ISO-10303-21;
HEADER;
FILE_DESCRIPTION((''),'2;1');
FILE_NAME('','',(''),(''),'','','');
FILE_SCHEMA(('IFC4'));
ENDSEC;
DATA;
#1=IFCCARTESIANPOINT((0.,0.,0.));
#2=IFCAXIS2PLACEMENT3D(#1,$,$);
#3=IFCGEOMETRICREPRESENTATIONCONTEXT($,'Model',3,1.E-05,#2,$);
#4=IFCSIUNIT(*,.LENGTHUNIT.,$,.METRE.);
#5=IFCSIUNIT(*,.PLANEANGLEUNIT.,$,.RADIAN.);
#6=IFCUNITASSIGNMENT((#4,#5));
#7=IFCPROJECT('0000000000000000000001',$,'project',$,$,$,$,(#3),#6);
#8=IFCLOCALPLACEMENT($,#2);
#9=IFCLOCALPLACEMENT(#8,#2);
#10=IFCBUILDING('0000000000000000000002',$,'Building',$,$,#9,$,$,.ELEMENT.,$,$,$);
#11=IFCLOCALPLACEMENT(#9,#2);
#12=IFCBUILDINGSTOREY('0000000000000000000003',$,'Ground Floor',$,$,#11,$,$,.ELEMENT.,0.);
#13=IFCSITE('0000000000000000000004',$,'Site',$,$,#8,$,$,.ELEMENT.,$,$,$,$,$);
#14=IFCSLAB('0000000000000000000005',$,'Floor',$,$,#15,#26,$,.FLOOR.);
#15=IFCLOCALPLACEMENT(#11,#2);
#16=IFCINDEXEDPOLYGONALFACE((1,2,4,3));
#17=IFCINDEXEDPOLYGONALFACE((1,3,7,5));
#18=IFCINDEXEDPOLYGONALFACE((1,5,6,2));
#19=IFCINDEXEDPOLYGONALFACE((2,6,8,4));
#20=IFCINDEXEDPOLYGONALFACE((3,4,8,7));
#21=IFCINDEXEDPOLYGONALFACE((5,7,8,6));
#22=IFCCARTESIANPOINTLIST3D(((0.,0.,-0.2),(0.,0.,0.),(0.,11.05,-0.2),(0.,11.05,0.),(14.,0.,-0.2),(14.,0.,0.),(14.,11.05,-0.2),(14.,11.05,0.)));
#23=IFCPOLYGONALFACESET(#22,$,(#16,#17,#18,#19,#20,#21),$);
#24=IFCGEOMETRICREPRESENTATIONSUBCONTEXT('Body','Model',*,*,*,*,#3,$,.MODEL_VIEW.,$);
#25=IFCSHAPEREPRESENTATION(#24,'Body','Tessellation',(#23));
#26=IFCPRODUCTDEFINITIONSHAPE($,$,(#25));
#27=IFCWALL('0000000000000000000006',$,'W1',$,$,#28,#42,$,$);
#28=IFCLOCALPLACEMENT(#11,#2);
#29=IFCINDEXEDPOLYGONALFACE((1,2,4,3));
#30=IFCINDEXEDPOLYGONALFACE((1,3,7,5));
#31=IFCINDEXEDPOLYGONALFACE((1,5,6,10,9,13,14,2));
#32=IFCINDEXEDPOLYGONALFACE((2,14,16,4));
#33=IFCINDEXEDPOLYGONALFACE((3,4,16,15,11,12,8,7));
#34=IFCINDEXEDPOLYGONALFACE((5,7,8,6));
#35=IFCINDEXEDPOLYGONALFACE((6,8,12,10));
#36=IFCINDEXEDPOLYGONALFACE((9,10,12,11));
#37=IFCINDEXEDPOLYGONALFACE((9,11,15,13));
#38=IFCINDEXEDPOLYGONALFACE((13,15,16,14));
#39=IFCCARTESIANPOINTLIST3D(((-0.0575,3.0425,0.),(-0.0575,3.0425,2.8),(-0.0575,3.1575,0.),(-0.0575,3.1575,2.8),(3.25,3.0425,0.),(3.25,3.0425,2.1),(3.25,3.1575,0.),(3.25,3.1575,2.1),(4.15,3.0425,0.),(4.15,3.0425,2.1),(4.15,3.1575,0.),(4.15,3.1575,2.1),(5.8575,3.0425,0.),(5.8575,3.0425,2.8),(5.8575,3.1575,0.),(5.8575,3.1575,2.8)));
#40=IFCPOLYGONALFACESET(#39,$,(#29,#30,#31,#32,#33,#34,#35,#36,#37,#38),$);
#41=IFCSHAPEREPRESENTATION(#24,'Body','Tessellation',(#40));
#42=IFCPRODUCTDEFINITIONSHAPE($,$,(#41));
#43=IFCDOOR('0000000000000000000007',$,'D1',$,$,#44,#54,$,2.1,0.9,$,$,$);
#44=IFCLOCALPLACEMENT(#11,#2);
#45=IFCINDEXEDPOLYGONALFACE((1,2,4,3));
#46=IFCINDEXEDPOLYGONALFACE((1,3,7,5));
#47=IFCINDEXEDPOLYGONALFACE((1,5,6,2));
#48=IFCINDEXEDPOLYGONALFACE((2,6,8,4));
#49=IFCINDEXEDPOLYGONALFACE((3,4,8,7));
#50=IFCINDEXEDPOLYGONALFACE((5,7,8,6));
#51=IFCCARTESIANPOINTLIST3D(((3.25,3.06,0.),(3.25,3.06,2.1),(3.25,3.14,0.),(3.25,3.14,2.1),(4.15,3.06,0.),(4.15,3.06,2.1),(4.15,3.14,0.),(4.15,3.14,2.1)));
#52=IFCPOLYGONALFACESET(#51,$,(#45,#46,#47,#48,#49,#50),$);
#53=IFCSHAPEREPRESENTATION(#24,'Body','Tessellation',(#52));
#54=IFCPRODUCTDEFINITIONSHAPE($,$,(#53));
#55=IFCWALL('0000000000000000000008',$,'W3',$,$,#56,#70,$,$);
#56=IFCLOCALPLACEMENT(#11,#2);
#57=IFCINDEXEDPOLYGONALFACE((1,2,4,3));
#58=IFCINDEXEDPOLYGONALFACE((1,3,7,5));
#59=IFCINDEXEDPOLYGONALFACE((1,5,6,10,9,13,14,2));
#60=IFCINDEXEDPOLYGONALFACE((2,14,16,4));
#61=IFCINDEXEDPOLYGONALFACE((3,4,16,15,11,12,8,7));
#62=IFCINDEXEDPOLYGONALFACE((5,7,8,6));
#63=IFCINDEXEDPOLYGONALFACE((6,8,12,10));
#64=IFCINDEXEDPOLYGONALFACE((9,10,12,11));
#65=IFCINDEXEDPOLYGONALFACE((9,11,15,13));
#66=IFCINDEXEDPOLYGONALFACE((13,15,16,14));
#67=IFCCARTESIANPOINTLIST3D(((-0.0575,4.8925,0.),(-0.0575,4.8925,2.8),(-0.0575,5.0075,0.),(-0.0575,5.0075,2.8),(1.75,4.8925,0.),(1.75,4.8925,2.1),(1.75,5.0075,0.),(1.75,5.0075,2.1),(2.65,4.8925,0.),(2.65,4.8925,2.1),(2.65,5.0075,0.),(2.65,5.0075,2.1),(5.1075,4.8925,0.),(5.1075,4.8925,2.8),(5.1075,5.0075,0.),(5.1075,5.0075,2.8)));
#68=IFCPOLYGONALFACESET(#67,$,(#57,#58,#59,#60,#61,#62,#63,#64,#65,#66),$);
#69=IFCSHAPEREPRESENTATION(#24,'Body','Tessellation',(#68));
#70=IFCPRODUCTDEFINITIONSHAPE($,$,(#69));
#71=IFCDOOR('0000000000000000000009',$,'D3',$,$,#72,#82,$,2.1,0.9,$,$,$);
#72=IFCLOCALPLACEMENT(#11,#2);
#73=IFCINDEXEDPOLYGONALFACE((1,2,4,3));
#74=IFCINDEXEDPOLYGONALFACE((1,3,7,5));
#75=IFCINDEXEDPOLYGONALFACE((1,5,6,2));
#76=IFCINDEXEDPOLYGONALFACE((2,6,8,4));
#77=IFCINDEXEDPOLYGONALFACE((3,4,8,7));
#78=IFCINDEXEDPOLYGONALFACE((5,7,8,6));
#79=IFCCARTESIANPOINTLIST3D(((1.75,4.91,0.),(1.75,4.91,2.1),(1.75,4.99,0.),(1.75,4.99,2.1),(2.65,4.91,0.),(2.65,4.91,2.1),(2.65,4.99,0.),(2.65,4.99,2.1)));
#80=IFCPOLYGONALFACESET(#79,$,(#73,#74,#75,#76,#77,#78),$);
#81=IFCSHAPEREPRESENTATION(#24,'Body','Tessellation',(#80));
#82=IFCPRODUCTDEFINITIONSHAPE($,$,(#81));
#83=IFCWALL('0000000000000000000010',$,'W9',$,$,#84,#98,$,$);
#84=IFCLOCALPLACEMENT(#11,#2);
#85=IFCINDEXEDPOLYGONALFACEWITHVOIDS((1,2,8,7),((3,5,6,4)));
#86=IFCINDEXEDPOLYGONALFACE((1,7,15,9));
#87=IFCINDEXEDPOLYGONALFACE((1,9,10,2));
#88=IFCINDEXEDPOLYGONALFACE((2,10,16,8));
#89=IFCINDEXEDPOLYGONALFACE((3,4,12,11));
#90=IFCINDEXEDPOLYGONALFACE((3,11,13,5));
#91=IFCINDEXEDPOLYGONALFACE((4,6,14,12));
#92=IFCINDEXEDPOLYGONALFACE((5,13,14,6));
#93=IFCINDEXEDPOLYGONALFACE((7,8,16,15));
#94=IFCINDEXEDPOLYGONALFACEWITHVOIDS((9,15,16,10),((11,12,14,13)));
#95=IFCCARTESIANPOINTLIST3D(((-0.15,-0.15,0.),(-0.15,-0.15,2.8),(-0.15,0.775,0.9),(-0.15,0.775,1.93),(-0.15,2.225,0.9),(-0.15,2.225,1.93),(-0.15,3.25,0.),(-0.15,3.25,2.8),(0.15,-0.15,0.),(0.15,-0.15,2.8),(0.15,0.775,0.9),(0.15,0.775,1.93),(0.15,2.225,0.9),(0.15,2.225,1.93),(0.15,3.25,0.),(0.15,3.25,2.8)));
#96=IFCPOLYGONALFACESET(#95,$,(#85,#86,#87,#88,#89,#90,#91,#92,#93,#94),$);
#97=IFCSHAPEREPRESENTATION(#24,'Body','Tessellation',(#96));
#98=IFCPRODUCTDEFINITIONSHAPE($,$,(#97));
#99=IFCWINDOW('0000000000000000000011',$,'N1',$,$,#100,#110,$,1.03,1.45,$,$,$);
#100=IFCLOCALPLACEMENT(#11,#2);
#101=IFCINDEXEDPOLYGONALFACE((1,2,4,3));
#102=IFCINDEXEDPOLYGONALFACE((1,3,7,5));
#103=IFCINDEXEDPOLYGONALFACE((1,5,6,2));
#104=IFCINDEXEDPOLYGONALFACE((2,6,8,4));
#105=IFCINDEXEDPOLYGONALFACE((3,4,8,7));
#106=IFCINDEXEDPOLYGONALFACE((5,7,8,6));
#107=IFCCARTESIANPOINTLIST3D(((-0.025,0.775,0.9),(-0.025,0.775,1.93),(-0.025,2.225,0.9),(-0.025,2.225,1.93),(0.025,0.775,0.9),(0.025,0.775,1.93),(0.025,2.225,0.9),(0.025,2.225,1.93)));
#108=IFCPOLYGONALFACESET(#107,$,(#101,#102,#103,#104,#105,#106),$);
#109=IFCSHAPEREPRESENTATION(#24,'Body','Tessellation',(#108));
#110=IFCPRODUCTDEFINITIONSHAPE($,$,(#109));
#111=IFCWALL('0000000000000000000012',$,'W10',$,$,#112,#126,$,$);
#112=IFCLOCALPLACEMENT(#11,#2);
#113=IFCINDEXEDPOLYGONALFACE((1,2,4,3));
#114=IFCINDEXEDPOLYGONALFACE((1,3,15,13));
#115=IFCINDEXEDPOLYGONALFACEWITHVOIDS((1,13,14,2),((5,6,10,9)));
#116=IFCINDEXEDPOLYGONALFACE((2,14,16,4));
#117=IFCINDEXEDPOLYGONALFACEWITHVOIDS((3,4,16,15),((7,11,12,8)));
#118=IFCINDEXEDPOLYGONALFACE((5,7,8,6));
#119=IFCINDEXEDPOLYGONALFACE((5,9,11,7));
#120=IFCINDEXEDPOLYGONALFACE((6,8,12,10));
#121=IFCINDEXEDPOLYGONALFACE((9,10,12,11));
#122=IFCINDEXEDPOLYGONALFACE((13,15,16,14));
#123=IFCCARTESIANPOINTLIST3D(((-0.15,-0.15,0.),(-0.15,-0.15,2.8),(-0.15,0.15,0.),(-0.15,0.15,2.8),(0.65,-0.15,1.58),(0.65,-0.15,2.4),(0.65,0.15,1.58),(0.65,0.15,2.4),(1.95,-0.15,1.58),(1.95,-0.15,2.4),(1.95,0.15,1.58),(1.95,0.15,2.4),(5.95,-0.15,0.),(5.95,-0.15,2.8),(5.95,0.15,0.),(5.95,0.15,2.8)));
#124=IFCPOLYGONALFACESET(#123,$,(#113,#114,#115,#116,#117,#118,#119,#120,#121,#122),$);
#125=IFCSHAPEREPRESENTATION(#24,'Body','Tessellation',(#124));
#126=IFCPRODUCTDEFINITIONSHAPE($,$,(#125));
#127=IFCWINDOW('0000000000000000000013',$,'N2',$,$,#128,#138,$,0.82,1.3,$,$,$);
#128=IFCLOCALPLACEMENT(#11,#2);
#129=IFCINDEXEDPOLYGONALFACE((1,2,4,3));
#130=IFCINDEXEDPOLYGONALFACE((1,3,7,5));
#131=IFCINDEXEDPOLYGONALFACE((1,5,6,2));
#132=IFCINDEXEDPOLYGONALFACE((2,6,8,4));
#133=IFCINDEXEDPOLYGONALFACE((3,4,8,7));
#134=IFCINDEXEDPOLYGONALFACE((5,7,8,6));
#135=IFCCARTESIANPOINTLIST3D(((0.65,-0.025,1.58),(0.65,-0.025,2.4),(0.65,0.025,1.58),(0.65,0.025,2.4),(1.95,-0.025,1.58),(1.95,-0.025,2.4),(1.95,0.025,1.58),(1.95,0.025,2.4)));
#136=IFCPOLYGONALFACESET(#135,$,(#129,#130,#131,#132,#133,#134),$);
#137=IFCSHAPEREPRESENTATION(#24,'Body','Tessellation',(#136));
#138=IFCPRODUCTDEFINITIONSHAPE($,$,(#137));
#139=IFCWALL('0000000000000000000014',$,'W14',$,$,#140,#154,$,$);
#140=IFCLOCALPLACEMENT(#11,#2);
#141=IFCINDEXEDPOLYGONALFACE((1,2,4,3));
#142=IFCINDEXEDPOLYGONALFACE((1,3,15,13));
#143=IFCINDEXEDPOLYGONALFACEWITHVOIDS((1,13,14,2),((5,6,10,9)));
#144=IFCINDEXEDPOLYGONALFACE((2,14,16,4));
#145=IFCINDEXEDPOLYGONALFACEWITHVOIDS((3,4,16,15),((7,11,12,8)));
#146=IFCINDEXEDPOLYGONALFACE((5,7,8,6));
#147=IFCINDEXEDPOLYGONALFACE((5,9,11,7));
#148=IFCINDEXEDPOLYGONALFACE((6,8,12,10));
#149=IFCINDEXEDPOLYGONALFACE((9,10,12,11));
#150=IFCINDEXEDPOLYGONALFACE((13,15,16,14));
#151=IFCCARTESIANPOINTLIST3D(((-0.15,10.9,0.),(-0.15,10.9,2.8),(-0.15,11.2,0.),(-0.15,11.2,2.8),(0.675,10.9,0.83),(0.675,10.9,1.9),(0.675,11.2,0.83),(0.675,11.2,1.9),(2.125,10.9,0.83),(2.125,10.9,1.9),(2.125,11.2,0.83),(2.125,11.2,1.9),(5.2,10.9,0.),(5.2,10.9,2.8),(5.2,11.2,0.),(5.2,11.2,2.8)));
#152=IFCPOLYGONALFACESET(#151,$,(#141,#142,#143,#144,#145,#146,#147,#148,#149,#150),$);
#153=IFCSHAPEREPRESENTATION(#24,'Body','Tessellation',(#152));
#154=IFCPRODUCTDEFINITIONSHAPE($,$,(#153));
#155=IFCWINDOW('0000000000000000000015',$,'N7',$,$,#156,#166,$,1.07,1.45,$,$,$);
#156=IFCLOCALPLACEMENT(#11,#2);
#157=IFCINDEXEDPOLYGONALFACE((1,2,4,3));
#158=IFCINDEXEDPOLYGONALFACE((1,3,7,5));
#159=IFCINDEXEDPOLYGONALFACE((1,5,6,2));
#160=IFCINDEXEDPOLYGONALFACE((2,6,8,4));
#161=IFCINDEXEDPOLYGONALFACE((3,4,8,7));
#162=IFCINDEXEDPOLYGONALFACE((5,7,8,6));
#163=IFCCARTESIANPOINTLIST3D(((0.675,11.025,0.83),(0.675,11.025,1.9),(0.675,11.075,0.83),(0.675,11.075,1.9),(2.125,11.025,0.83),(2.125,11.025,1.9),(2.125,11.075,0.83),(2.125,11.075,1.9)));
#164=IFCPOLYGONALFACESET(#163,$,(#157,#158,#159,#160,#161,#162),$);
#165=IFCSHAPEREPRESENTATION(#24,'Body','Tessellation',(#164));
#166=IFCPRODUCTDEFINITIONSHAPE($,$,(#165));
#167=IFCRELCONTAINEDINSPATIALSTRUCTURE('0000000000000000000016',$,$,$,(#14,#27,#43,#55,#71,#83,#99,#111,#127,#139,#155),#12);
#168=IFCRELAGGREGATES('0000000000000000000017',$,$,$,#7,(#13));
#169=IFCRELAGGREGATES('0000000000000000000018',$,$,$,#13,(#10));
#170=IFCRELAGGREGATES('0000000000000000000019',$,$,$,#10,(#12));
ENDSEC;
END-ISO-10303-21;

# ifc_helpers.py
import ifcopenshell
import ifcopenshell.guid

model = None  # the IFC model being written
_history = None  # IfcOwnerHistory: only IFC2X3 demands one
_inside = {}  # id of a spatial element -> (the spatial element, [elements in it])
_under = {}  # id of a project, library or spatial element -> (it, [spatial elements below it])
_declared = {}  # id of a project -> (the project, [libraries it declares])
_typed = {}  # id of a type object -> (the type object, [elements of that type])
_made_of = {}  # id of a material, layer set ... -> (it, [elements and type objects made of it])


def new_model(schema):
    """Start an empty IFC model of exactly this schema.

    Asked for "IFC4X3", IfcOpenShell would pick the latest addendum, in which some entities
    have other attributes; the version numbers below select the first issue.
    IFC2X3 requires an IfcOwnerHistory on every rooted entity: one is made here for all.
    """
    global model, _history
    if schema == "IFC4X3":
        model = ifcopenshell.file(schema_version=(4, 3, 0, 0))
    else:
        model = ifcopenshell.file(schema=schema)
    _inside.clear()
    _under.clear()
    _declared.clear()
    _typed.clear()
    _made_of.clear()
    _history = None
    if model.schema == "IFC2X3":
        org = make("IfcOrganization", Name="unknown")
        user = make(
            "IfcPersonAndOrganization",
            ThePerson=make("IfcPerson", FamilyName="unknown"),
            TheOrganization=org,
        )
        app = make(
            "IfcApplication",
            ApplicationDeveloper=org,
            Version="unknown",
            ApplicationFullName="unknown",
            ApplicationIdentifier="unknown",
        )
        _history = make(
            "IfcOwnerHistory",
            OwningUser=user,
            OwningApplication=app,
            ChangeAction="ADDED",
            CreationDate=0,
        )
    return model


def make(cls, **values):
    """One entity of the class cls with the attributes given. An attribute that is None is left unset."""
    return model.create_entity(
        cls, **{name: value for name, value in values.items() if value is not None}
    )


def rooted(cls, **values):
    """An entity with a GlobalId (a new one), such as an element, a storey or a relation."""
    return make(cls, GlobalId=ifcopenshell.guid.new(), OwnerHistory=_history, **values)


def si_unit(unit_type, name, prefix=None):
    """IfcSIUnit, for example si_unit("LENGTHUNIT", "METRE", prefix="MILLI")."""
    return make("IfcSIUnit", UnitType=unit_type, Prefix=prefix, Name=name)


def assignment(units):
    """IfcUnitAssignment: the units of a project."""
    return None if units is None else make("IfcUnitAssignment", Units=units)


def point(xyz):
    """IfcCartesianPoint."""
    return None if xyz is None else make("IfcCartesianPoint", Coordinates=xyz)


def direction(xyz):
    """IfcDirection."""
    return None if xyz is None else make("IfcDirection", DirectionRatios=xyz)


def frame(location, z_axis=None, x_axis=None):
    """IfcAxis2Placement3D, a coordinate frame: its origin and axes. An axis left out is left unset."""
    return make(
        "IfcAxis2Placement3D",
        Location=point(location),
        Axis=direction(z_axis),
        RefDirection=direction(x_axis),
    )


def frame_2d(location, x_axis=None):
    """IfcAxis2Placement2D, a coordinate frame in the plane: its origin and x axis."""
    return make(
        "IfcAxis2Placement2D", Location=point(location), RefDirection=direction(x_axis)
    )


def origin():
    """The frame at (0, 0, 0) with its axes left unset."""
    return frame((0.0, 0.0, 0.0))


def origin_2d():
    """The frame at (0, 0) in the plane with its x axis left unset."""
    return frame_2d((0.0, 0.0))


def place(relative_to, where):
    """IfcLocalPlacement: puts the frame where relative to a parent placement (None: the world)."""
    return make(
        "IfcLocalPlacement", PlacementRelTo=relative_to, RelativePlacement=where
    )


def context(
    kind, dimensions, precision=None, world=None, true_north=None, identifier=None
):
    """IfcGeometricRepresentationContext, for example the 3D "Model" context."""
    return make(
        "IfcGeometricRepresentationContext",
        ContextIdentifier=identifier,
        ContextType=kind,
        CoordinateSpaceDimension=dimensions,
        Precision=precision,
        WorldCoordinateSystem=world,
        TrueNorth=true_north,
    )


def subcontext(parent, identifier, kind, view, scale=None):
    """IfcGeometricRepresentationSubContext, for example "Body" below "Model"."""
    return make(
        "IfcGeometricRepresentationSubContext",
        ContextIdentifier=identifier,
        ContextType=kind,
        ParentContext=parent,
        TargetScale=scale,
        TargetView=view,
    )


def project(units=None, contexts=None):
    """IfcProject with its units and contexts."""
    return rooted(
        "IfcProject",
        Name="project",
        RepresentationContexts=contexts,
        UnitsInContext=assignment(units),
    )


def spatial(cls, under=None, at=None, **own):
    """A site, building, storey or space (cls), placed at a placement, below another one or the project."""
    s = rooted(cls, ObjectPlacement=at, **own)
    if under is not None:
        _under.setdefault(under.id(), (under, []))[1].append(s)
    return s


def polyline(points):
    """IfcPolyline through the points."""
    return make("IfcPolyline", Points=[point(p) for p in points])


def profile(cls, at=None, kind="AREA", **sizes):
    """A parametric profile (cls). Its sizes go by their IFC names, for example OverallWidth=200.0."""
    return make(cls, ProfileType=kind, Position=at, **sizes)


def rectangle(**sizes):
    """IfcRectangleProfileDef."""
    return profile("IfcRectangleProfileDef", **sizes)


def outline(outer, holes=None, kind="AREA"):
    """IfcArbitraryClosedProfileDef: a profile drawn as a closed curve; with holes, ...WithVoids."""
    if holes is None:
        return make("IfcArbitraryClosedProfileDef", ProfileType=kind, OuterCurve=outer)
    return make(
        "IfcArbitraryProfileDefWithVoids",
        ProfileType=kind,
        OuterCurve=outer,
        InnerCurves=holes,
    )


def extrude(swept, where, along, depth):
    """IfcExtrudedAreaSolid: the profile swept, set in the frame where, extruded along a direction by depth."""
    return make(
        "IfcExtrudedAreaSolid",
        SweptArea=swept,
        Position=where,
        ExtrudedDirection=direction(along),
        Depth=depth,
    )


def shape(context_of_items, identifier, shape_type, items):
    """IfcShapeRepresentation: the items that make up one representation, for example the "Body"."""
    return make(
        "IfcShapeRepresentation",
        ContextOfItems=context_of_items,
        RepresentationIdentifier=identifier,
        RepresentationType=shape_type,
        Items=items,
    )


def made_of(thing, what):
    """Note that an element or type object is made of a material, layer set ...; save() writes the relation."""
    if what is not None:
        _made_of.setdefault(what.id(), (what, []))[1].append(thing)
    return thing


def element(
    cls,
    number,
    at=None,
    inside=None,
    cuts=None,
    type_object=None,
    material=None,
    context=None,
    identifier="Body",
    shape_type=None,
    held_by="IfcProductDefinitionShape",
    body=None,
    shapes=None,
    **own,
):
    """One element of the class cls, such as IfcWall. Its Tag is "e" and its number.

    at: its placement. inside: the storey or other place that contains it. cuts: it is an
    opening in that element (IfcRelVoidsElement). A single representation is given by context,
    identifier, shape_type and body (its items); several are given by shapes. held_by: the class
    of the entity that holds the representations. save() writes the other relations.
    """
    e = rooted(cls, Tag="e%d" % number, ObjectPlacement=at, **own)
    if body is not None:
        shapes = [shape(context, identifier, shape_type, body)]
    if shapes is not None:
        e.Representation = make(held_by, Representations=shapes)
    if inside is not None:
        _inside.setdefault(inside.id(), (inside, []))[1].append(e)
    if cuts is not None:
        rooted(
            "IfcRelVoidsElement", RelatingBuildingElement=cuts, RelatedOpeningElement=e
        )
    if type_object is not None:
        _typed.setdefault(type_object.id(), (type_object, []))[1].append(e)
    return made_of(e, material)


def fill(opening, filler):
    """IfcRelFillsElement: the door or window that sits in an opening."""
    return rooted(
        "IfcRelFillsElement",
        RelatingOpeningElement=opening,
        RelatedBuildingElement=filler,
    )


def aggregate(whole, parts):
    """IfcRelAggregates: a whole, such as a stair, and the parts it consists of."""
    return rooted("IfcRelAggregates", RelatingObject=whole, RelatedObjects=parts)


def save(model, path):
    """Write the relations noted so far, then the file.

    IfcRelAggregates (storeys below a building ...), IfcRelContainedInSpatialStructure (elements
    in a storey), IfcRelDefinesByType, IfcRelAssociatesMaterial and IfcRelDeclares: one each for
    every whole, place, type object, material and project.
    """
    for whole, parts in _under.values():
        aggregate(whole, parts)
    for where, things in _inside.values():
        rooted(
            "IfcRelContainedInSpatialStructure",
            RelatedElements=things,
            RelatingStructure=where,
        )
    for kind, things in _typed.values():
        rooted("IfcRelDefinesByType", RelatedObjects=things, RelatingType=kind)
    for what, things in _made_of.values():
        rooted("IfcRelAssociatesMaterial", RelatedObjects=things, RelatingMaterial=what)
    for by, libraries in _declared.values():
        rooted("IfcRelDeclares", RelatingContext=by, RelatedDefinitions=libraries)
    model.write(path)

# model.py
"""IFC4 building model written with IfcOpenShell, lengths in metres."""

from ifc_helpers import new_model, si_unit, frame, frame_2d, origin, origin_2d, place, context, subcontext, project, spatial, polyline, rectangle, outline, extrude, element, fill, save


model = new_model("IFC4")

# Units and contexts
model_context = context("Model", 3, precision=1e-05, world=origin())
body_context = subcontext(model_context, "Body", "Model", "MODEL_VIEW")
ifc_project = project(units=[si_unit("LENGTHUNIT", "METRE"), si_unit("PLANEANGLEUNIT", "RADIAN")], contexts=[model_context])

# Site, building, storey
site_placement = place(None, origin())
site = spatial("IfcSite", under=ifc_project, at=site_placement, Name="Site", CompositionType="ELEMENT")
building_placement = place(site_placement, origin())
building = spatial("IfcBuilding", under=site, at=building_placement, Name="Building", CompositionType="ELEMENT")
storey_placement = place(building_placement, origin())
storey = spatial("IfcBuildingStorey", under=building, at=storey_placement, Name="Ground Floor", CompositionType="ELEMENT", Elevation=0.0)

# Slab
slab_placement = place(storey_placement, origin())
element("IfcSlab", 1, at=slab_placement, inside=storey, Name="Floor", PredefinedType="FLOOR", context=body_context, shape_type="SweptSolid", body=[
    extrude(outline(polyline([(0.0, 0.0), (14.0, 0.0), (14.0, 11.05), (0.0, 11.05), (0.0, 0.0)])), origin(), (0.0, 0.0, -1.0), 0.2),
])

# Walls, openings, doors
wall_1_placement = place(storey_placement, frame((0.0, 3.1, 0.0), x_axis=(1.0, 0.0, 0.0)))
wall_1 = element("IfcWall", 2, at=wall_1_placement, inside=storey, Name="W1", context=body_context, shape_type="SweptSolid", body=[
    extrude(rectangle(XDim=5.915, YDim=0.115, at=frame_2d((2.9, 0.0))), origin(), (0.0, 0.0, 1.0), 2.8),
])
opening_1_placement = place(wall_1_placement, frame((3.7, 0.0, 0.0)))
opening_1 = element("IfcOpeningElement", 3, at=opening_1_placement, cuts=wall_1, context=body_context, shape_type="SweptSolid", body=[
    extrude(rectangle(XDim=0.9, YDim=0.215, at=origin_2d()), origin(), (0.0, 0.0, 1.0), 2.1),
])
door_1_placement = place(opening_1_placement, origin())
door_1 = element("IfcDoor", 4, at=door_1_placement, inside=storey, Name="D1", OverallHeight=2.1, OverallWidth=0.9, context=body_context, shape_type="SweptSolid", body=[
    extrude(rectangle(XDim=0.9, YDim=0.08, at=origin_2d()), origin(), (0.0, 0.0, 1.0), 2.1),
])
fill(opening_1, door_1)
wall_2_placement = place(storey_placement, frame((0.0, 4.95, 0.0), x_axis=(1.0, 0.0, 0.0)))
wall_2 = element("IfcWall", 5, at=wall_2_placement, inside=storey, Name="W3", context=body_context, shape_type="SweptSolid", body=[
    extrude(rectangle(XDim=5.165, YDim=0.115, at=frame_2d((2.525, 0.0))), origin(), (0.0, 0.0, 1.0), 2.8),
])
opening_2_placement = place(wall_2_placement, frame((2.2, 0.0, 0.0)))
opening_2 = element("IfcOpeningElement", 6, at=opening_2_placement, cuts=wall_2, context=body_context, shape_type="SweptSolid", body=[
    extrude(rectangle(XDim=0.9, YDim=0.215, at=origin_2d()), origin(), (0.0, 0.0, 1.0), 2.1),
])
door_2_placement = place(opening_2_placement, origin())
door_2 = element("IfcDoor", 7, at=door_2_placement, inside=storey, Name="D3", OverallHeight=2.1, OverallWidth=0.9, context=body_context, shape_type="SweptSolid", body=[
    extrude(rectangle(XDim=0.9, YDim=0.08, at=origin_2d()), origin(), (0.0, 0.0, 1.0), 2.1),
])
fill(opening_2, door_2)

# Walls, openings, windows
wall_3_placement = place(storey_placement, frame((0.0, 0.0, 0.0), x_axis=(0.0, 1.0, 0.0)))
wall_3 = element("IfcWall", 8, at=wall_3_placement, inside=storey, Name="W9", context=body_context, shape_type="SweptSolid", body=[
    extrude(rectangle(XDim=3.4, YDim=0.3, at=frame_2d((1.55, 0.0))), origin(), (0.0, 0.0, 1.0), 2.8),
])
opening_3_placement = place(wall_3_placement, frame((1.5, 0.0, 0.9)))
opening_3 = element("IfcOpeningElement", 9, at=opening_3_placement, cuts=wall_3, context=body_context, shape_type="SweptSolid", body=[
    extrude(rectangle(XDim=1.45, YDim=0.4, at=origin_2d()), origin(), (0.0, 0.0, 1.0), 1.03),
])
window_1_placement = place(opening_3_placement, origin())
window_1 = element("IfcWindow", 10, at=window_1_placement, inside=storey, Name="N1", OverallHeight=1.03, OverallWidth=1.45, context=body_context, shape_type="SweptSolid", body=[
    extrude(rectangle(XDim=1.45, YDim=0.05, at=origin_2d()), origin(), (0.0, 0.0, 1.0), 1.03),
])
fill(opening_3, window_1)
wall_4_placement = place(storey_placement, frame((0.0, 0.0, 0.0), x_axis=(1.0, 0.0, 0.0)))
wall_4 = element("IfcWall", 11, at=wall_4_placement, inside=storey, Name="W10", context=body_context, shape_type="SweptSolid", body=[
    extrude(rectangle(XDim=6.1, YDim=0.3, at=frame_2d((2.9, 0.0))), origin(), (0.0, 0.0, 1.0), 2.8),
])
opening_4_placement = place(wall_4_placement, frame((1.3, 0.0, 1.58)))
opening_4 = element("IfcOpeningElement", 12, at=opening_4_placement, cuts=wall_4, context=body_context, shape_type="SweptSolid", body=[
    extrude(rectangle(XDim=1.3, YDim=0.4, at=origin_2d()), origin(), (0.0, 0.0, 1.0), 0.82),
])
window_2_placement = place(opening_4_placement, origin())
window_2 = element("IfcWindow", 13, at=window_2_placement, inside=storey, Name="N2", OverallHeight=0.82, OverallWidth=1.3, context=body_context, shape_type="SweptSolid", body=[
    extrude(rectangle(XDim=1.3, YDim=0.05, at=origin_2d()), origin(), (0.0, 0.0, 1.0), 0.82),
])
fill(opening_4, window_2)
wall_5_placement = place(storey_placement, frame((0.0, 11.05, 0.0), x_axis=(1.0, 0.0, 0.0)))
wall_5 = element("IfcWall", 14, at=wall_5_placement, inside=storey, Name="W14", context=body_context, shape_type="SweptSolid", body=[
    extrude(rectangle(XDim=5.35, YDim=0.3, at=frame_2d((2.525, 0.0))), origin(), (0.0, 0.0, 1.0), 2.8),
])
opening_5_placement = place(wall_5_placement, frame((1.4, 0.0, 0.83)))
opening_5 = element("IfcOpeningElement", 15, at=opening_5_placement, cuts=wall_5, context=body_context, shape_type="SweptSolid", body=[
    extrude(rectangle(XDim=1.45, YDim=0.4, at=origin_2d()), origin(), (0.0, 0.0, 1.0), 1.07),
])
window_3_placement = place(opening_5_placement, origin())
window_3 = element("IfcWindow", 16, at=window_3_placement, inside=storey, Name="N7", OverallHeight=1.07, OverallWidth=1.45, context=body_context, shape_type="SweptSolid", body=[
    extrude(rectangle(XDim=1.45, YDim=0.05, at=origin_2d()), origin(), (0.0, 0.0, 1.0), 1.07),
])
fill(opening_5, window_3)

save(model, "model.ifc")
